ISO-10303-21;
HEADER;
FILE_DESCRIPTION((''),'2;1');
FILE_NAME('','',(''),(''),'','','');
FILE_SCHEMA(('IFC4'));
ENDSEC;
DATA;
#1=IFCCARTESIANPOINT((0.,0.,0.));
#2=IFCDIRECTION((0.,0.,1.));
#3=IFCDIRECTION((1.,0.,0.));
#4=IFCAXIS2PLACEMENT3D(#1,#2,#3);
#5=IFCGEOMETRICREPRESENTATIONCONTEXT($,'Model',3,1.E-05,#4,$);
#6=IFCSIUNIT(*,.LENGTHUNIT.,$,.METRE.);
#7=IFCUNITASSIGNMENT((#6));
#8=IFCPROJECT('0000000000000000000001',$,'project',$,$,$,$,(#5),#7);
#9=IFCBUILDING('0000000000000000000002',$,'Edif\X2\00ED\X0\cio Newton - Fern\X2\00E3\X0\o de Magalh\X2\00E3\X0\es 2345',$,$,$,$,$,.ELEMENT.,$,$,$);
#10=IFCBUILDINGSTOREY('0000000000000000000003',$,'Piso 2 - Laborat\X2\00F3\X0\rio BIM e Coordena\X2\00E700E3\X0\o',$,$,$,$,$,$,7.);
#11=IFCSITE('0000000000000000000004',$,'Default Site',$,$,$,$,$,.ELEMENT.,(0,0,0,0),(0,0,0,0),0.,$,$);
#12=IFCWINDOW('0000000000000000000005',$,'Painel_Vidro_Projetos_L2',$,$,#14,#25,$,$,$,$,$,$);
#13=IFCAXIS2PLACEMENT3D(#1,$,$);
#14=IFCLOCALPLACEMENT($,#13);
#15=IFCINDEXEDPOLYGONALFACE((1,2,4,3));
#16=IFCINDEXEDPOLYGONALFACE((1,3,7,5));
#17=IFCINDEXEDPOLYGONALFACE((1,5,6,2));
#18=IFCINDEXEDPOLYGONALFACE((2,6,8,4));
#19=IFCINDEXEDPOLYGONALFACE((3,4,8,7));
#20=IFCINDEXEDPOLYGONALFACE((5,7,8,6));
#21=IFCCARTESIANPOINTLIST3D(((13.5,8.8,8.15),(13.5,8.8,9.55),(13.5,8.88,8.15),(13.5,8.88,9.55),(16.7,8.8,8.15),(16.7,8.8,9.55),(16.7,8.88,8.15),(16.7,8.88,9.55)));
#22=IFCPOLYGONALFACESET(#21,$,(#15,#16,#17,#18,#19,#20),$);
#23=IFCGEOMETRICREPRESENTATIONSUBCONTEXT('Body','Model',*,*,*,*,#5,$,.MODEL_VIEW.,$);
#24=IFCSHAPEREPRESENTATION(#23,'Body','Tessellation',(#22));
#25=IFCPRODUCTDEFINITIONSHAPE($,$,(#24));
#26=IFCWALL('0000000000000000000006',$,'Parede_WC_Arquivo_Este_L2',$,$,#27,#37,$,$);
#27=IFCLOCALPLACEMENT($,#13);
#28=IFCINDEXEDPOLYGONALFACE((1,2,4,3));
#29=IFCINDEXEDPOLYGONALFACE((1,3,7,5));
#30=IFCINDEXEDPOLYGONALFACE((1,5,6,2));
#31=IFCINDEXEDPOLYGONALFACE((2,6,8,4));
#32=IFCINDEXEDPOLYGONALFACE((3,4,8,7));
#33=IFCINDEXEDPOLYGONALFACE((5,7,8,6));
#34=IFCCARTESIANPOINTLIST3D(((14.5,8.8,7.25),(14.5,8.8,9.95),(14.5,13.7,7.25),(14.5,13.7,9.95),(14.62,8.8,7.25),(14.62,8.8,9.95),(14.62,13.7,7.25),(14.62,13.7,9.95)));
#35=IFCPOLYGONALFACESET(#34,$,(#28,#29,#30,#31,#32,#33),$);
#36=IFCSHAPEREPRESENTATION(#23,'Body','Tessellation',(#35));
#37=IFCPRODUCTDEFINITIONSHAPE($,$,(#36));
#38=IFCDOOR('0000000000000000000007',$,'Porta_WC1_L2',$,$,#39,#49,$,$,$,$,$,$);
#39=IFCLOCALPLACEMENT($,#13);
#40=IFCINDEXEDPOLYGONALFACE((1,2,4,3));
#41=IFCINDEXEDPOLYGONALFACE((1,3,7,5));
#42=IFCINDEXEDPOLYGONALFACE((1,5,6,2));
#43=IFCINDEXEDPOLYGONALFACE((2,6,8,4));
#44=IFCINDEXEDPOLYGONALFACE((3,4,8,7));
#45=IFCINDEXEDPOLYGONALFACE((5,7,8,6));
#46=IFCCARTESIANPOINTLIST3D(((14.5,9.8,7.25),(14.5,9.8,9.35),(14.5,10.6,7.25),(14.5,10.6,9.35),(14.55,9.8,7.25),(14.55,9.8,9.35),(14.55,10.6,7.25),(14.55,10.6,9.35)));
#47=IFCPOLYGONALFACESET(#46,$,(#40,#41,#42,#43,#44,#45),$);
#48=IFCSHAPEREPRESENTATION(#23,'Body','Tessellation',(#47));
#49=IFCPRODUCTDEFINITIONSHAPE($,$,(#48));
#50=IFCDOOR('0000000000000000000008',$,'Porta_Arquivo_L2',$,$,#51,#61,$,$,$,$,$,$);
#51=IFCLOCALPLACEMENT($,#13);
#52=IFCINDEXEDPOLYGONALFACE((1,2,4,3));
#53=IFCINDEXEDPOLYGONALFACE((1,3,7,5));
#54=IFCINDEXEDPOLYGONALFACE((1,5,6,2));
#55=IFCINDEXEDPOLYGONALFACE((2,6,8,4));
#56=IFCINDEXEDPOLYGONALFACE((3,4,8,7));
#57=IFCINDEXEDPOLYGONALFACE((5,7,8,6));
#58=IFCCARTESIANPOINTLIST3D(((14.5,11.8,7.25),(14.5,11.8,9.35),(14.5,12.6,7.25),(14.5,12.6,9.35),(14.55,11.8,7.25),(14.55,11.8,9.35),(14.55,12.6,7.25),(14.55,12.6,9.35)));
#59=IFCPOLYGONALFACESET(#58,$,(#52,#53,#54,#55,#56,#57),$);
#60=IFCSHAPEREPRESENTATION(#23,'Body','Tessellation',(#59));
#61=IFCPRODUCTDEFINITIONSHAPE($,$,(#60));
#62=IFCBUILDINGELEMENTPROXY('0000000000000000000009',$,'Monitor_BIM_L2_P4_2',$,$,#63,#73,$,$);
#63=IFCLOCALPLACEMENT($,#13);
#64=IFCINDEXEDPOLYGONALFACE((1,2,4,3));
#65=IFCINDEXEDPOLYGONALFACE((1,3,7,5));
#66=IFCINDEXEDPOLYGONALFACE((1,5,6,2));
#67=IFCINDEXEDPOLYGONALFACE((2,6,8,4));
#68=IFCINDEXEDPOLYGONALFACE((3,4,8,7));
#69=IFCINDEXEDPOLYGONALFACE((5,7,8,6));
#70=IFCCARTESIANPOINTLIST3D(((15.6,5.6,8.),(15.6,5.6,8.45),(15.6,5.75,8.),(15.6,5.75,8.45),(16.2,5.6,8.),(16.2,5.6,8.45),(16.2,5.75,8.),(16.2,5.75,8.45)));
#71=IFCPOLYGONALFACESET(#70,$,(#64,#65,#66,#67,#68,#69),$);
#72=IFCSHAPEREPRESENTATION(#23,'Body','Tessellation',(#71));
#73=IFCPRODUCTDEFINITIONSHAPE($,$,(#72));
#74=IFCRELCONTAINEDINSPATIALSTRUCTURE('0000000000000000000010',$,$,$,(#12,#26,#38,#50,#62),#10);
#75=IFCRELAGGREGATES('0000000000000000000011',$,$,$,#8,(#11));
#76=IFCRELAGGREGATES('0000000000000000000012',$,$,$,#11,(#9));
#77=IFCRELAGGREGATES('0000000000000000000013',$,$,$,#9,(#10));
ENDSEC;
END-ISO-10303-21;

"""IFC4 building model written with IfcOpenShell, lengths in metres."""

from ifc_helpers import new_model, si_unit, frame, frame_2d, origin_with_axes, place, context, subcontext, project, spatial, rectangle, extrude, element, save


model = new_model("IFC4")

# Units and contexts
model_context = context("Model", 3, precision=1e-05, world=origin_with_axes())
body_context = subcontext(model_context, "Body", "Model", "MODEL_VIEW")
ifc_project = project(units=[si_unit("LENGTHUNIT", "METRE")], contexts=[model_context])

# Site, building, storey
site = spatial("IfcSite", under=ifc_project, Name="Default Site", CompositionType="ELEMENT", RefLatitude=(0, 0, 0, 0), RefLongitude=(0, 0, 0, 0), RefElevation=0.0)
building = spatial("IfcBuilding", under=site, Name="Edifício Newton - Fernão de Magalhães 2345", CompositionType="ELEMENT")
storey = spatial("IfcBuildingStorey", under=building, Name="Piso 2 - Laboratório BIM e Coordenação", Elevation=7.0)

# Window
window_1_placement = place(None, frame((13.5, 8.8, 8.15), z_axis=(0.0, 0.0, 1.0), x_axis=(1.0, 0.0, 0.0)))
element("IfcWindow", 1, at=window_1_placement, inside=storey, Name="Painel_Vidro_Projetos_L2", context=body_context, shape_type="SweptSolid", body=[
    extrude(rectangle(XDim=3.2, YDim=0.08, at=frame_2d((1.6, 0.04))), origin_with_axes(), (0.0, 0.0, 1.0), 1.4),
])

# Wall
wall_1_placement = place(None, frame((14.5, 8.8, 7.25), z_axis=(0.0, 0.0, 1.0), x_axis=(1.0, 0.0, 0.0)))
element("IfcWall", 2, at=wall_1_placement, inside=storey, Name="Parede_WC_Arquivo_Este_L2", context=body_context, shape_type="SweptSolid", body=[
    extrude(rectangle(XDim=0.12, YDim=4.9, at=frame_2d((0.06, 2.45))), origin_with_axes(), (0.0, 0.0, 1.0), 2.7),
])

# Doors
for number, where, z_axis, x_axis, name in (
    (3, (14.5, 9.8, 7.25), (0.0, 0.0, 1.0), (1.0, 0.0, 0.0), "Porta_WC1_L2"),
    (4, (14.5, 11.8, 7.25), (0.0, 0.0, 1.0), (1.0, 0.0, 0.0), "Porta_Arquivo_L2"),
):
    element("IfcDoor", number, at=place(None, frame(where, z_axis=z_axis, x_axis=x_axis)), inside=storey, Name=name, context=body_context, shape_type="SweptSolid", body=[
        extrude(rectangle(XDim=0.05, YDim=0.8, at=frame_2d((0.025, 0.4))), origin_with_axes(), (0.0, 0.0, 1.0), 2.1),
    ])

# Building element proxy
proxy_placement = place(None, frame((15.6, 5.6, 8.0), z_axis=(0.0, 0.0, 1.0), x_axis=(1.0, 0.0, 0.0)))
element("IfcBuildingElementProxy", 5, at=proxy_placement, inside=storey, Name="Monitor_BIM_L2_P4_2", context=body_context, shape_type="SweptSolid", body=[
    extrude(rectangle(XDim=0.6, YDim=0.15, at=frame_2d((0.3, 0.075))), origin_with_axes(), (0.0, 0.0, 1.0), 0.45),
])

save(model, "model.ifc")
